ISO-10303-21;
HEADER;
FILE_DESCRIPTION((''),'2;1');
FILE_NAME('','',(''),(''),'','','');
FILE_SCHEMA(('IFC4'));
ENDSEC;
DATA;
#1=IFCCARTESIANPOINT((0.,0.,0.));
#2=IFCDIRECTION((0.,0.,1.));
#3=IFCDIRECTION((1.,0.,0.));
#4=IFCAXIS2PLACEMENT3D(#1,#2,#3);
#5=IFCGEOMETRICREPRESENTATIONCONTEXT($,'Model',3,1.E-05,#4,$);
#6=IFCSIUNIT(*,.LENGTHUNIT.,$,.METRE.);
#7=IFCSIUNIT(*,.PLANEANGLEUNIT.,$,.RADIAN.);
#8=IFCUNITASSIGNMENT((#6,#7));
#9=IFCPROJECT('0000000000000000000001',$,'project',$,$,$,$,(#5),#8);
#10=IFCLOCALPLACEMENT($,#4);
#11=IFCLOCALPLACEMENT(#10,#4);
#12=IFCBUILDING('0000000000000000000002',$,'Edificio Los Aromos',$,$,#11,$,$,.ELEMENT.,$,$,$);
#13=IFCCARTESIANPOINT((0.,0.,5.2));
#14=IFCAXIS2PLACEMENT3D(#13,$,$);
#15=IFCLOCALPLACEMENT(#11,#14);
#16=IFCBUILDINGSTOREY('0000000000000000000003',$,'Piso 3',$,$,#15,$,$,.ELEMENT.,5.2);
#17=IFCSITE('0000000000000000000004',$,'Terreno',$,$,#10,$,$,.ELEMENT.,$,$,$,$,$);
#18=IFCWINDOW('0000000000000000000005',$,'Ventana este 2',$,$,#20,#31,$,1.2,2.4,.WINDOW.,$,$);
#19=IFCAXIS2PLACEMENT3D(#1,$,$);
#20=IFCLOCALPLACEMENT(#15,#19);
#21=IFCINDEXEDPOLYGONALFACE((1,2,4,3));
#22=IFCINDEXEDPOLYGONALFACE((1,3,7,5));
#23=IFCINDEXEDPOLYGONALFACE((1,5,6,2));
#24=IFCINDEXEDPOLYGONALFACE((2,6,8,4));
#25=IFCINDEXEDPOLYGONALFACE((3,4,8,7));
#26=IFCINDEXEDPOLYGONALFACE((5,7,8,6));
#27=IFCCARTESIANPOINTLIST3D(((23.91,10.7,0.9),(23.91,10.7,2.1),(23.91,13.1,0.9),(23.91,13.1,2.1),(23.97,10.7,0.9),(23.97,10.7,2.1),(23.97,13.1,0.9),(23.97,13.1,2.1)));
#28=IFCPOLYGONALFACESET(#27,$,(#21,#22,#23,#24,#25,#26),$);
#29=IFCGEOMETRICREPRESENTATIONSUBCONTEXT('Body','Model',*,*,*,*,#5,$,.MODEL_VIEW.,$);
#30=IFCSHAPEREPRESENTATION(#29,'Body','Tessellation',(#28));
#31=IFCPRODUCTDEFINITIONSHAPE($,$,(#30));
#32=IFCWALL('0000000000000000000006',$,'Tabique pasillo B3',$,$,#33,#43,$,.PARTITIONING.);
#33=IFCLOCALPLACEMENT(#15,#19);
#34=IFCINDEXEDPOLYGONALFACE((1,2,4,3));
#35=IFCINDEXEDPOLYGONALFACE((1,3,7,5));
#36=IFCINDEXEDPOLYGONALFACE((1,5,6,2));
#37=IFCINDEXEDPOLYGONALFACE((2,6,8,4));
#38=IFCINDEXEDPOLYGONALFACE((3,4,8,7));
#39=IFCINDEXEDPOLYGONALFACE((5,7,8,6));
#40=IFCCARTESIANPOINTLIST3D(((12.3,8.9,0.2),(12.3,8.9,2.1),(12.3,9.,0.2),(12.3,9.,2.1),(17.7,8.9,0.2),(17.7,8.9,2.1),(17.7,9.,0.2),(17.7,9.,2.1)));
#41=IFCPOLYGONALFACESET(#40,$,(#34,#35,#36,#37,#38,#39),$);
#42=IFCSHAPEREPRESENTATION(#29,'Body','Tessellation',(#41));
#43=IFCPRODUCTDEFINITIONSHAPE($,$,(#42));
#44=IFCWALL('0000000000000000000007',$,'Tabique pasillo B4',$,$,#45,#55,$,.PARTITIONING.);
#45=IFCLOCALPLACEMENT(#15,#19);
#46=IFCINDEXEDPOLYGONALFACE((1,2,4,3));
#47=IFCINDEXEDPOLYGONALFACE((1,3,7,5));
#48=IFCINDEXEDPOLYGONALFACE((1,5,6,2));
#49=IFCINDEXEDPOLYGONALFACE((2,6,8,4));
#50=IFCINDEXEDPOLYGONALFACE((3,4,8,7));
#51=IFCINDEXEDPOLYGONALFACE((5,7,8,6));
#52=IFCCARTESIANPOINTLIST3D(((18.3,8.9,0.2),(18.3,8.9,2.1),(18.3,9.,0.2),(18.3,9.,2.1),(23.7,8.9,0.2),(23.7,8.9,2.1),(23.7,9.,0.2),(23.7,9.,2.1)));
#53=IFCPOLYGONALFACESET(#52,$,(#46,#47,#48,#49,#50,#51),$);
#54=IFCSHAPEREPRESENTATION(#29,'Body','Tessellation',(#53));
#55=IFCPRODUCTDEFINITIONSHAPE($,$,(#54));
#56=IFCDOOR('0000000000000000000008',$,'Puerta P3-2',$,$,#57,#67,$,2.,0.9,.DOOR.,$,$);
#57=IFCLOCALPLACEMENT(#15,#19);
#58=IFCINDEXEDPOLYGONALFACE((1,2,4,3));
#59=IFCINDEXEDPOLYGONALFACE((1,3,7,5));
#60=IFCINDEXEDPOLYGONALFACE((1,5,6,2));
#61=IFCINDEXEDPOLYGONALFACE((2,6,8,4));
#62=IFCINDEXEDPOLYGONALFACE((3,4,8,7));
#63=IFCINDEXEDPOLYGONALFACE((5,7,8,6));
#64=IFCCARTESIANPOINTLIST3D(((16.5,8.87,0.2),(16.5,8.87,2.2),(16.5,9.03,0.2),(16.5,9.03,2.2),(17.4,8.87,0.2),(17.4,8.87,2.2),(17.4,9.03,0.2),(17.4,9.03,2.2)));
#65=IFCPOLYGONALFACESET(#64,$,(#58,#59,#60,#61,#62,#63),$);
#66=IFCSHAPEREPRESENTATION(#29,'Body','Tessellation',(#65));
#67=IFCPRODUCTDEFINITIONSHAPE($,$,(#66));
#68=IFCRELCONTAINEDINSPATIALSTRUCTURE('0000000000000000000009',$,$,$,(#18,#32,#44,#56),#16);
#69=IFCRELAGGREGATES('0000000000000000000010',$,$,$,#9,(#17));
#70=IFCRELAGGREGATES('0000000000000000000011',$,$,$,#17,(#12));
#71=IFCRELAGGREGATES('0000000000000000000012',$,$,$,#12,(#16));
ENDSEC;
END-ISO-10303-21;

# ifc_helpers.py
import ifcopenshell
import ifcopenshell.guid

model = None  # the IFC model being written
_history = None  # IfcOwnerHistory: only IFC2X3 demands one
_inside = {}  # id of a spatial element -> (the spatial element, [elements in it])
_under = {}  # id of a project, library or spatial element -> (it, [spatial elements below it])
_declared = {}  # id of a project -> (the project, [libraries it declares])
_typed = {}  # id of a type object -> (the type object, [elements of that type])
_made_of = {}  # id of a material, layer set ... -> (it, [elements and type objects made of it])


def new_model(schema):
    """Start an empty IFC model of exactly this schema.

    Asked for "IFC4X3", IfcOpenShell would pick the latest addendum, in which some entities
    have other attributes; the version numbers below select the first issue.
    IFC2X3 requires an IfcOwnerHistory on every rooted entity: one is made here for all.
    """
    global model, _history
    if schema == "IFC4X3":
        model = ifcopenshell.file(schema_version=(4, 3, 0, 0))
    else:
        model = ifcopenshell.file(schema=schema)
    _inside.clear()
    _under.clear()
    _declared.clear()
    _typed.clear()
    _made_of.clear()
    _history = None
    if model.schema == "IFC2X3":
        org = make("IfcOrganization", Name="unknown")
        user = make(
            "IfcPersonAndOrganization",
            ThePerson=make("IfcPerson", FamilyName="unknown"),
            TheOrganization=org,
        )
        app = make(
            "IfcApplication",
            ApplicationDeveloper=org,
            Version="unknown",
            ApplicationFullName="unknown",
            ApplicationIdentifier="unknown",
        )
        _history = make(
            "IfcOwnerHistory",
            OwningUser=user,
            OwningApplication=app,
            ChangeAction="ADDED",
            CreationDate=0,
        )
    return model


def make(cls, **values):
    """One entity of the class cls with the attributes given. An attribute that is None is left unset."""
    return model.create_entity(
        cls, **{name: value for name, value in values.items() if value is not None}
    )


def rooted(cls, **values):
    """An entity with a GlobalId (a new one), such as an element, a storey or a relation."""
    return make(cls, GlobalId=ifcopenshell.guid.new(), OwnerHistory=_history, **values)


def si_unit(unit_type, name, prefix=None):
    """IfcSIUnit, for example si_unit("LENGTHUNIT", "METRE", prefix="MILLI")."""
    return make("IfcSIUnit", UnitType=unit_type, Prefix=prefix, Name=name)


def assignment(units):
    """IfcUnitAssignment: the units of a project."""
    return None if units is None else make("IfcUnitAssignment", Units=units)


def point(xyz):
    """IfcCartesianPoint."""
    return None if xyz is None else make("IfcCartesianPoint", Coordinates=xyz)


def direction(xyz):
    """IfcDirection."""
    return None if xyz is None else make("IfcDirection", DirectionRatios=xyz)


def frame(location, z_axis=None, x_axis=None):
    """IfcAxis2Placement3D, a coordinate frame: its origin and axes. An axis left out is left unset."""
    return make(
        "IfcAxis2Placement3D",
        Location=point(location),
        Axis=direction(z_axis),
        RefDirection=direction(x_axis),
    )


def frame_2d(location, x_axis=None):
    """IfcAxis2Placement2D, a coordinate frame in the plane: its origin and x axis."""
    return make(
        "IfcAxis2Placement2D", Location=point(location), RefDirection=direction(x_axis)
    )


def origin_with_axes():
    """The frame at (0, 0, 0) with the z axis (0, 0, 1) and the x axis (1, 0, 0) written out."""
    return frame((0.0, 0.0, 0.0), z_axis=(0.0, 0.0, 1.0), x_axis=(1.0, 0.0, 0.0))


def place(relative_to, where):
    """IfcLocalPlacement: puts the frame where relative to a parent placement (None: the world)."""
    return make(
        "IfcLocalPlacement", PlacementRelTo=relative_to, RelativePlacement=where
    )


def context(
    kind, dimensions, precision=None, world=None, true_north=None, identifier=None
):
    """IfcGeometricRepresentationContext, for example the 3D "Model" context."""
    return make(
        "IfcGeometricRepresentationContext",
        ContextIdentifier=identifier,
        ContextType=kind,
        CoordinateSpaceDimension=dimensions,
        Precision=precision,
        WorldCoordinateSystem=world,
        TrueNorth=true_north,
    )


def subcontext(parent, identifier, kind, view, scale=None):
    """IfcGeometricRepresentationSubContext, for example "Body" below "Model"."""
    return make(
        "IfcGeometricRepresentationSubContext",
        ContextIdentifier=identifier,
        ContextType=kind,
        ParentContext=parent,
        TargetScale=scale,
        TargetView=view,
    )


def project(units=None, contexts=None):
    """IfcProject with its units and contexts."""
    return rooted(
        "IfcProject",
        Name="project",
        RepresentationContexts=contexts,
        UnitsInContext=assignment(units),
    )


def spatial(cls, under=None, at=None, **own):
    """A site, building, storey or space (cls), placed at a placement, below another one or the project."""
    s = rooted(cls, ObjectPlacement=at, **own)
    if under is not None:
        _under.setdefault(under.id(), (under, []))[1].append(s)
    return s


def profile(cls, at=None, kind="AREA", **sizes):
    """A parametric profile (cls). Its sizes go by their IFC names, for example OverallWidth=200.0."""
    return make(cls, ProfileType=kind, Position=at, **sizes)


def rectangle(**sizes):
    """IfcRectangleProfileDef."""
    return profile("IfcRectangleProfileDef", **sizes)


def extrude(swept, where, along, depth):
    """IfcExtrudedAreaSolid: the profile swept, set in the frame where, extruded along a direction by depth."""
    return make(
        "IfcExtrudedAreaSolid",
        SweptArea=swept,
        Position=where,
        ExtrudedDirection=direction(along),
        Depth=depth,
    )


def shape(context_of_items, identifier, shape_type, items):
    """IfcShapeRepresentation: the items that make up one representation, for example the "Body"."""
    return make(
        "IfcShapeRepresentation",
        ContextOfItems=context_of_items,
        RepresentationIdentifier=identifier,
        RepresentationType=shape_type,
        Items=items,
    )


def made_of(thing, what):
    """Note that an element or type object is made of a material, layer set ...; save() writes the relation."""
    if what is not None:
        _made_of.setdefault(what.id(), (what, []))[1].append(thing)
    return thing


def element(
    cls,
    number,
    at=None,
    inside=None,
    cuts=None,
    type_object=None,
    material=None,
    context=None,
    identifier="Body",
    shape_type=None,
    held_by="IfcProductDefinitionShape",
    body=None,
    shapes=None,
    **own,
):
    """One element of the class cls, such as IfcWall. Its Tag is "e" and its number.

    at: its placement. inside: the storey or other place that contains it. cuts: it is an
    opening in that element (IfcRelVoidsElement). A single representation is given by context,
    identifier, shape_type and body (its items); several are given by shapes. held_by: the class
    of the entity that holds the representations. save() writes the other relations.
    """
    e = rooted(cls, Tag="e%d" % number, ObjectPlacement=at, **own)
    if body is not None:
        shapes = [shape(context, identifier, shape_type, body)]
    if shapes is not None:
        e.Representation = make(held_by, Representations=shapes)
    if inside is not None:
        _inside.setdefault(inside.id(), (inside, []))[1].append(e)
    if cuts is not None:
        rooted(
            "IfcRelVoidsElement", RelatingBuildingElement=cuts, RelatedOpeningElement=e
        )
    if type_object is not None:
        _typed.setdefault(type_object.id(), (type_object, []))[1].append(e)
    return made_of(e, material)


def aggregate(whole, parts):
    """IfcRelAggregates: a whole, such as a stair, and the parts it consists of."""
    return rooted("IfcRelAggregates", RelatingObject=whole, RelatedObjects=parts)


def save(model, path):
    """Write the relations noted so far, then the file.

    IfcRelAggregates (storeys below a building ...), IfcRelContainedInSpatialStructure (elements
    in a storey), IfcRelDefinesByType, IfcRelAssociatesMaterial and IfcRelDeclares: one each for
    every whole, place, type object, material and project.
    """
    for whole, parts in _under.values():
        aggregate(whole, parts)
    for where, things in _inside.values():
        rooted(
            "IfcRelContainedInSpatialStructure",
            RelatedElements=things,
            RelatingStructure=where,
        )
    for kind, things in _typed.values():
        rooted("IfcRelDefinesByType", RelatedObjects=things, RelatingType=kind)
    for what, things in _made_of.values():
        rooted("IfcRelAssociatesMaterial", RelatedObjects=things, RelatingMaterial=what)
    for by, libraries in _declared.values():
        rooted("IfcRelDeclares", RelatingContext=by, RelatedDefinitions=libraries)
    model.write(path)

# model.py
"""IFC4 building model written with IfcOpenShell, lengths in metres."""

from ifc_helpers import new_model, si_unit, frame, frame_2d, origin_with_axes, place, context, subcontext, project, spatial, rectangle, extrude, element, save


model = new_model("IFC4")

# Units and contexts
model_context = context("Model", 3, precision=1e-05, world=origin_with_axes())
body_context = subcontext(model_context, "Body", "Model", "MODEL_VIEW")
ifc_project = project(units=[si_unit("LENGTHUNIT", "METRE"), si_unit("PLANEANGLEUNIT", "RADIAN")], contexts=[model_context])

# Site, building, storey
site_placement = place(None, origin_with_axes())
site = spatial("IfcSite", under=ifc_project, at=site_placement, Name="Terreno", CompositionType="ELEMENT")
building_placement = place(site_placement, origin_with_axes())
building = spatial("IfcBuilding", under=site, at=building_placement, Name="Edificio Los Aromos", CompositionType="ELEMENT")
storey_placement = place(building_placement, frame((0.0, 0.0, 5.2)))
storey = spatial("IfcBuildingStorey", under=building, at=storey_placement, Name="Piso 3", CompositionType="ELEMENT", Elevation=5.2)

# Window
window_1_placement = place(storey_placement, frame((23.91, 10.7, 0.9)))
element("IfcWindow", 1, at=window_1_placement, inside=storey, Name="Ventana este 2", OverallHeight=1.2, OverallWidth=2.4, PredefinedType="WINDOW", context=body_context, shape_type="SweptSolid", body=[
    extrude(rectangle(XDim=0.06, YDim=2.4, at=frame_2d((0.03, 1.2))), origin_with_axes(), (0.0, 0.0, 1.0), 1.2),
])

# Walls
for number, where, name in (
    (2, (12.3, 8.9, 0.2), "Tabique pasillo B3"),
    (3, (18.3, 8.9, 0.2), "Tabique pasillo B4"),
):
    element("IfcWall", number, at=place(storey_placement, frame(where)), inside=storey, Name=name, PredefinedType="PARTITIONING", context=body_context, shape_type="SweptSolid", body=[
        extrude(rectangle(XDim=5.4, YDim=0.1, at=frame_2d((2.7, 0.05))), origin_with_axes(), (0.0, 0.0, 1.0), 1.9),
    ])

# Door
door_placement = place(storey_placement, frame((16.5, 8.87, 0.2)))
element("IfcDoor", 4, at=door_placement, inside=storey, Name="Puerta P3-2", OverallHeight=2.0, OverallWidth=0.9, PredefinedType="DOOR", context=body_context, shape_type="SweptSolid", body=[
    extrude(rectangle(XDim=0.9, YDim=0.16, at=frame_2d((0.45, 0.08))), origin_with_axes(), (0.0, 0.0, 1.0), 2.0),
])

save(model, "model.ifc")
